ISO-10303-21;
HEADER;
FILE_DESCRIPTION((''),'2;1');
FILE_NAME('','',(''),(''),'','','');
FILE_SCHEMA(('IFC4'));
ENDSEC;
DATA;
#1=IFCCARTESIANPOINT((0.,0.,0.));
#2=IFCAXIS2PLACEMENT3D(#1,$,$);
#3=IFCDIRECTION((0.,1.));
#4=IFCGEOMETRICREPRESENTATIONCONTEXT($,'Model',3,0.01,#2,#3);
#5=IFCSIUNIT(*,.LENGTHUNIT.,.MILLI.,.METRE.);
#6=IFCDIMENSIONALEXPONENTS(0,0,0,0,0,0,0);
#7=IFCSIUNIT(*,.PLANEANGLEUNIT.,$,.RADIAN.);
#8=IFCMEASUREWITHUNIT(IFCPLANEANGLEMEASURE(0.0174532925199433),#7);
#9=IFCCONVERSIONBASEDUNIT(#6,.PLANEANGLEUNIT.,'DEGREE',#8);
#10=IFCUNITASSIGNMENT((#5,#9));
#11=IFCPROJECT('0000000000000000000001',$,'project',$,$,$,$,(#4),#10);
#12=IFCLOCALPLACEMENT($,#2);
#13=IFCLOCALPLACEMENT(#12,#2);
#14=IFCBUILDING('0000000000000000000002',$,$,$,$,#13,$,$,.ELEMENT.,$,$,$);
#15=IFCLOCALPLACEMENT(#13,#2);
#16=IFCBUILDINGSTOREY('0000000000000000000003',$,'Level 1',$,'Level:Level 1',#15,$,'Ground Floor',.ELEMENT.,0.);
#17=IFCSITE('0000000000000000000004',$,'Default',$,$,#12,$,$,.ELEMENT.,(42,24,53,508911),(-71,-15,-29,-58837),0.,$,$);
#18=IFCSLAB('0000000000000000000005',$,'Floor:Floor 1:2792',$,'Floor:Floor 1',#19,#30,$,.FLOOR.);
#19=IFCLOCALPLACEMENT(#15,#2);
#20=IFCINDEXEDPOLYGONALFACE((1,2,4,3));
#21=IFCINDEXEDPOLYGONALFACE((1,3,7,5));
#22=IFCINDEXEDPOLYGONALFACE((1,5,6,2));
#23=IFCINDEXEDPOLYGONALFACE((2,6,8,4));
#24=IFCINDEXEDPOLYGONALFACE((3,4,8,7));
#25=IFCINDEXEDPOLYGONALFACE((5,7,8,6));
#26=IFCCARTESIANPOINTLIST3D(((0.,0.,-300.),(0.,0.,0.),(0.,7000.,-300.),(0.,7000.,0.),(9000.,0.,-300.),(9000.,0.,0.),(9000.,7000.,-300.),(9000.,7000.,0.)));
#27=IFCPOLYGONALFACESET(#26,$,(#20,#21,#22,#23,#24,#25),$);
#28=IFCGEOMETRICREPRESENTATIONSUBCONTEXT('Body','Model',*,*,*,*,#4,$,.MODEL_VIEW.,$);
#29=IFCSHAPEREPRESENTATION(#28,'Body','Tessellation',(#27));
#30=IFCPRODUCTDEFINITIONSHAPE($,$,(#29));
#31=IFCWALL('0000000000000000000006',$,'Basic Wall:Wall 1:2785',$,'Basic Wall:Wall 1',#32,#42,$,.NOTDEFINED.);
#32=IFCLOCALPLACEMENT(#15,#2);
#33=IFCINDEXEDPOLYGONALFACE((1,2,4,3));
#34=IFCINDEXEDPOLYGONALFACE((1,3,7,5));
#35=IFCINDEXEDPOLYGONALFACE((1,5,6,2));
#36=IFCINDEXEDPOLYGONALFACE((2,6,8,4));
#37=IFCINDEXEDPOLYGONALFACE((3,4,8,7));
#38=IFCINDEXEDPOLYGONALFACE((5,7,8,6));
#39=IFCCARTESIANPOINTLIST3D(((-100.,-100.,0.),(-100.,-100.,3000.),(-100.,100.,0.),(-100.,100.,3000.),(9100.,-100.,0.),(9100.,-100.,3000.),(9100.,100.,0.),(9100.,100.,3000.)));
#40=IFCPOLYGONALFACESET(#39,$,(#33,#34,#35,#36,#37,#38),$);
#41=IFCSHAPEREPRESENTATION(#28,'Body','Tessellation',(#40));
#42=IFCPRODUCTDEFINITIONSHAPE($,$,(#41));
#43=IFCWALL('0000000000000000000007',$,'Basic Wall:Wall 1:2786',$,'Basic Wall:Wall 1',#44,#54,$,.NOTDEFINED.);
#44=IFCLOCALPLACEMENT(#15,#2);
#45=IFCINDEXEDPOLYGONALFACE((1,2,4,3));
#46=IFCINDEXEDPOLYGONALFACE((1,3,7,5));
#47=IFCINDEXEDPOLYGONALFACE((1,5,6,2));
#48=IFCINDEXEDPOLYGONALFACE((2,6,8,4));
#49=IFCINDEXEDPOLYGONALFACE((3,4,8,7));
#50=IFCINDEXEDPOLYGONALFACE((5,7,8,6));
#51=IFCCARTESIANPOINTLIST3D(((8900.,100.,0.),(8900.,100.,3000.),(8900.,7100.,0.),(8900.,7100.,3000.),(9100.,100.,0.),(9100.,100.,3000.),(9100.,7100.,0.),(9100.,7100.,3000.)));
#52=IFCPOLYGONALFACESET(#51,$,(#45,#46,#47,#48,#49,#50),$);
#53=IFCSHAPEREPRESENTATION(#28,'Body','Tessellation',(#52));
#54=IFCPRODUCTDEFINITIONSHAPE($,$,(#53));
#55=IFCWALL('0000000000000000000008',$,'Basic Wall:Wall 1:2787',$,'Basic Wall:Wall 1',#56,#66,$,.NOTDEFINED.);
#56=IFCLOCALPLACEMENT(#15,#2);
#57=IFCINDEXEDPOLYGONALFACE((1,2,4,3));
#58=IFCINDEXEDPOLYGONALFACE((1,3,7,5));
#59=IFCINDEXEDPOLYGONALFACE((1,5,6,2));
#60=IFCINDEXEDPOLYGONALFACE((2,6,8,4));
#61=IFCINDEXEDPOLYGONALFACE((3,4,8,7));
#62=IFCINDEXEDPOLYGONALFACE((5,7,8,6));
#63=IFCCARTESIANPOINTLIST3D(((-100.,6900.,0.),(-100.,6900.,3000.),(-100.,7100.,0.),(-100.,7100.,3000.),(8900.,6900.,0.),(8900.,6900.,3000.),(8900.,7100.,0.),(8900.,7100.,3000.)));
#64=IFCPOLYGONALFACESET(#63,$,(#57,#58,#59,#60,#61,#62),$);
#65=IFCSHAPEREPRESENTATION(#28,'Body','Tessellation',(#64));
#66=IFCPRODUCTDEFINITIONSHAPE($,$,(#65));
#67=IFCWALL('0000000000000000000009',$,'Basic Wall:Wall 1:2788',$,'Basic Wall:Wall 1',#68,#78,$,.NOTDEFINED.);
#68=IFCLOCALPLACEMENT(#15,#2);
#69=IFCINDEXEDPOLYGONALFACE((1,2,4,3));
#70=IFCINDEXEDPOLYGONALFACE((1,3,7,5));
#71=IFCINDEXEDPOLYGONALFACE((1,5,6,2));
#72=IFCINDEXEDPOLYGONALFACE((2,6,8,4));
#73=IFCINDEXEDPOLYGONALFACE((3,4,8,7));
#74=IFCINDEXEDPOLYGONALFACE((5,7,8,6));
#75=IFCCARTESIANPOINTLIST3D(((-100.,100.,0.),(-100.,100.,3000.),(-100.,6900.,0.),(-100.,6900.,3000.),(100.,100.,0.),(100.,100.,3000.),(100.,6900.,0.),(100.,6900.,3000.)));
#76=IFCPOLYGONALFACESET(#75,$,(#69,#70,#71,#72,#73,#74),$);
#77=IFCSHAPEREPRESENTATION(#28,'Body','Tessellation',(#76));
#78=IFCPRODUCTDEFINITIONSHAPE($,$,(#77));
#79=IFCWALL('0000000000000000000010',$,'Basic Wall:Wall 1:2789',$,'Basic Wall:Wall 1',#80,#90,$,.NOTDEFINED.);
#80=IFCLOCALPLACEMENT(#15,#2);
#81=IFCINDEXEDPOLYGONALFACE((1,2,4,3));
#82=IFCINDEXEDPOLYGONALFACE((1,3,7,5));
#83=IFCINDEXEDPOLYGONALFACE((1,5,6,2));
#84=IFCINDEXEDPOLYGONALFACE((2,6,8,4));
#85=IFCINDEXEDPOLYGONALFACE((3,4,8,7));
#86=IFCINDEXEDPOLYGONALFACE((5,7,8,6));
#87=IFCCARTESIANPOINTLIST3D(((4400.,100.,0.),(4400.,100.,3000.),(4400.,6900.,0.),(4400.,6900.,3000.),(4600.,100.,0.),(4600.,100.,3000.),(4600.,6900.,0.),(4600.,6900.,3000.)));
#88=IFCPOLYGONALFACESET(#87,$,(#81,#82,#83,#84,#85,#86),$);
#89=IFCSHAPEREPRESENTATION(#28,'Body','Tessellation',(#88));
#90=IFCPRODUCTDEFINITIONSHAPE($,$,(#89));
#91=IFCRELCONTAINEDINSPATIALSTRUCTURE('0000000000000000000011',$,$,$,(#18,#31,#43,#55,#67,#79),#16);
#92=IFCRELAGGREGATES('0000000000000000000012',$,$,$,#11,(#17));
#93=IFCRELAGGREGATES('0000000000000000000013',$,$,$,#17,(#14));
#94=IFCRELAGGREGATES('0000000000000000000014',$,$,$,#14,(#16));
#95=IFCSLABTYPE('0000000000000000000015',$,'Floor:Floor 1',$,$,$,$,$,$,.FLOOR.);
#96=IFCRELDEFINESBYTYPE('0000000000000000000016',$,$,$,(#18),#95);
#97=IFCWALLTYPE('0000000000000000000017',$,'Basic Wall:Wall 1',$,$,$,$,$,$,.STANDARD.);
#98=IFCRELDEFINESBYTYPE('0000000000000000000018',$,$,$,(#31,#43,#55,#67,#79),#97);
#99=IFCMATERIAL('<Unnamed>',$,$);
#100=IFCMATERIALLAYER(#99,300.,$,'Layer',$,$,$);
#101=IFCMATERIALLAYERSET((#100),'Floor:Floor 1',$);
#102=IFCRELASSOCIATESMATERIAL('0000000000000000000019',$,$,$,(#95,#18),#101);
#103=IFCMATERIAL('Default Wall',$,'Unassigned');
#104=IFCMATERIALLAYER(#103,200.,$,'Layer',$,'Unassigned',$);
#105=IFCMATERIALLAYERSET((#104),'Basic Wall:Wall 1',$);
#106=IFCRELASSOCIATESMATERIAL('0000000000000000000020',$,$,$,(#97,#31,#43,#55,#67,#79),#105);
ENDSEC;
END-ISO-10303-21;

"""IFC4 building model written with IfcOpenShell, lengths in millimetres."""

from ifc_helpers import new_model, entity, si_unit, converted_unit, direction, frame, frame_2d, origin, origin_2d_with_axis, place, context, subcontext, project, spatial, rectangle, extrude, material, layer, layer_set, layer_usage, type_object, element, save


model = new_model("IFC4")

# Units and contexts
model_context = context("Model", 3, precision=0.01, world=origin(), true_north=direction((0.0, 1.0)))
body_context = subcontext(model_context, "Body", "Model", "MODEL_VIEW")
ifc_project = project(units=[si_unit("LENGTHUNIT", "METRE", prefix="MILLI"), converted_unit("PLANEANGLEUNIT", "DEGREE", entity("IfcPlaneAngleMeasure", 0.0174532925199433), si_unit("PLANEANGLEUNIT", "RADIAN"), dimensions=[0, 0, 0, 0, 0, 0, 0])], contexts=[model_context])

# Site, building, storey
site_placement = place(None, origin())
site = spatial("IfcSite", under=ifc_project, at=site_placement, Name="Default", CompositionType="ELEMENT", RefLatitude=(42, 24, 53, 508911), RefLongitude=(-71, -15, -29, -58837), RefElevation=0.0)
building_placement = place(site_placement, origin())
building = spatial("IfcBuilding", under=site, at=building_placement, CompositionType="ELEMENT")
storey_placement = place(building_placement, origin())
storey = spatial("IfcBuildingStorey", under=building, at=storey_placement, Name="Level 1", ObjectType="Level:Level 1", LongName="Ground Floor", CompositionType="ELEMENT", Elevation=0.0)

# Slab
ifc_material_1 = material(Name="<Unnamed>")
ifc_layer_1 = layer(ifc_material_1, 300.0, Name="Layer")
ifc_layer_set_1 = layer_set([ifc_layer_1], Name="Floor:Floor 1")
ifc_layer_usage_1 = layer_usage(ifc_layer_set_1, "AXIS3", "POSITIVE", 0.0)
slab_type = type_object("IfcSlabType", Name="Floor:Floor 1", PredefinedType="FLOOR", material=ifc_layer_set_1)
slab_placement = place(storey_placement, origin())
element("IfcSlab", 1, at=slab_placement, inside=storey, type_object=slab_type, material=ifc_layer_usage_1, Name="Floor:Floor 1:2792", ObjectType="Floor:Floor 1", PredefinedType="FLOOR", context=body_context, shape_type="SweptSolid", body=[
    extrude(rectangle(XDim=7000.0, YDim=9000.0, at=origin_2d_with_axis()), frame((4500.0, 3500.0, 0.0), z_axis=(0.0, 0.0, -1.0), x_axis=(0.0, 1.0, 0.0)), (0.0, 0.0, 1.0), 300.0),
])

# Walls
ifc_material_2 = material(Name="Default Wall", Category="Unassigned")
ifc_layer_2 = layer(ifc_material_2, 200.0, Name="Layer", Category="Unassigned")
ifc_layer_set_2 = layer_set([ifc_layer_2], Name="Basic Wall:Wall 1")
ifc_layer_usage_2 = layer_usage(ifc_layer_set_2, "AXIS2", "NEGATIVE", 100.0)
wall_type = type_object("IfcWallType", Name="Basic Wall:Wall 1", PredefinedType="STANDARD", material=ifc_layer_set_2)
wall_1_placement = place(storey_placement, frame((-100.0, 0.0, 0.0)))
element("IfcWall", 2, at=wall_1_placement, inside=storey, type_object=wall_type, material=ifc_layer_usage_2, Name="Basic Wall:Wall 1:2785", ObjectType="Basic Wall:Wall 1", PredefinedType="NOTDEFINED", context=body_context, shape_type="SweptSolid", body=[
    extrude(rectangle(XDim=9200.0, YDim=200.0, at=frame_2d((4600.0, 0.0), x_axis=(-1.0, 0.0))), origin(), (0.0, 0.0, 1.0), 3000.0),
])
ifc_layer_usage_3 = layer_usage(ifc_layer_set_2, "AXIS2", "NEGATIVE", 100.0)
wall_2_placement = place(storey_placement, frame((9000.0, 100.0, 0.0), z_axis=(0.0, 0.0, 1.0), x_axis=(0.0, 1.0, 0.0)))
element("IfcWall", 3, at=wall_2_placement, inside=storey, type_object=wall_type, material=ifc_layer_usage_3, Name="Basic Wall:Wall 1:2786", ObjectType="Basic Wall:Wall 1", PredefinedType="NOTDEFINED", context=body_context, shape_type="SweptSolid", body=[
    extrude(rectangle(XDim=7000.0, YDim=200.0, at=frame_2d((3500.0, 0.0), x_axis=(-1.0, 0.0))), origin(), (0.0, 0.0, 1.0), 3000.0),
])
ifc_layer_usage_4 = layer_usage(ifc_layer_set_2, "AXIS2", "NEGATIVE", 100.0)
wall_3_placement = place(storey_placement, frame((8900.0, 7000.0, 0.0), z_axis=(0.0, 0.0, 1.0), x_axis=(-1.0, 0.0, 0.0)))
element("IfcWall", 4, at=wall_3_placement, inside=storey, type_object=wall_type, material=ifc_layer_usage_4, Name="Basic Wall:Wall 1:2787", ObjectType="Basic Wall:Wall 1", PredefinedType="NOTDEFINED", context=body_context, shape_type="SweptSolid", body=[
    extrude(rectangle(XDim=9000.0, YDim=200.0, at=frame_2d((4500.0, 0.0), x_axis=(-1.0, 0.0))), origin(), (0.0, 0.0, 1.0), 3000.0),
])
ifc_layer_usage_5 = layer_usage(ifc_layer_set_2, "AXIS2", "NEGATIVE", 100.0)
wall_4_placement = place(storey_placement, frame((0.0, 6900.0, 0.0), z_axis=(0.0, 0.0, 1.0), x_axis=(0.0, -1.0, 0.0)))
element("IfcWall", 5, at=wall_4_placement, inside=storey, type_object=wall_type, material=ifc_layer_usage_5, Name="Basic Wall:Wall 1:2788", ObjectType="Basic Wall:Wall 1", PredefinedType="NOTDEFINED", context=body_context, shape_type="SweptSolid", body=[
    extrude(rectangle(XDim=6800.0, YDim=200.0, at=frame_2d((3400.0, 0.0), x_axis=(-1.0, 0.0))), origin(), (0.0, 0.0, 1.0), 3000.0),
])
ifc_layer_usage_6 = layer_usage(ifc_layer_set_2, "AXIS2", "NEGATIVE", 100.0)
wall_5_placement = place(storey_placement, frame((4500.0, 100.0, 0.0), z_axis=(0.0, 0.0, 1.0), x_axis=(0.0, 1.0, 0.0)))
element("IfcWall", 6, at=wall_5_placement, inside=storey, type_object=wall_type, material=ifc_layer_usage_6, Name="Basic Wall:Wall 1:2789", ObjectType="Basic Wall:Wall 1", PredefinedType="NOTDEFINED", context=body_context, shape_type="SweptSolid", body=[
    extrude(rectangle(XDim=6800.0, YDim=200.0, at=frame_2d((3400.0, 0.0), x_axis=(-1.0, 0.0))), origin(), (0.0, 0.0, 1.0), 3000.0),
])

save(model, "model.ifc")
